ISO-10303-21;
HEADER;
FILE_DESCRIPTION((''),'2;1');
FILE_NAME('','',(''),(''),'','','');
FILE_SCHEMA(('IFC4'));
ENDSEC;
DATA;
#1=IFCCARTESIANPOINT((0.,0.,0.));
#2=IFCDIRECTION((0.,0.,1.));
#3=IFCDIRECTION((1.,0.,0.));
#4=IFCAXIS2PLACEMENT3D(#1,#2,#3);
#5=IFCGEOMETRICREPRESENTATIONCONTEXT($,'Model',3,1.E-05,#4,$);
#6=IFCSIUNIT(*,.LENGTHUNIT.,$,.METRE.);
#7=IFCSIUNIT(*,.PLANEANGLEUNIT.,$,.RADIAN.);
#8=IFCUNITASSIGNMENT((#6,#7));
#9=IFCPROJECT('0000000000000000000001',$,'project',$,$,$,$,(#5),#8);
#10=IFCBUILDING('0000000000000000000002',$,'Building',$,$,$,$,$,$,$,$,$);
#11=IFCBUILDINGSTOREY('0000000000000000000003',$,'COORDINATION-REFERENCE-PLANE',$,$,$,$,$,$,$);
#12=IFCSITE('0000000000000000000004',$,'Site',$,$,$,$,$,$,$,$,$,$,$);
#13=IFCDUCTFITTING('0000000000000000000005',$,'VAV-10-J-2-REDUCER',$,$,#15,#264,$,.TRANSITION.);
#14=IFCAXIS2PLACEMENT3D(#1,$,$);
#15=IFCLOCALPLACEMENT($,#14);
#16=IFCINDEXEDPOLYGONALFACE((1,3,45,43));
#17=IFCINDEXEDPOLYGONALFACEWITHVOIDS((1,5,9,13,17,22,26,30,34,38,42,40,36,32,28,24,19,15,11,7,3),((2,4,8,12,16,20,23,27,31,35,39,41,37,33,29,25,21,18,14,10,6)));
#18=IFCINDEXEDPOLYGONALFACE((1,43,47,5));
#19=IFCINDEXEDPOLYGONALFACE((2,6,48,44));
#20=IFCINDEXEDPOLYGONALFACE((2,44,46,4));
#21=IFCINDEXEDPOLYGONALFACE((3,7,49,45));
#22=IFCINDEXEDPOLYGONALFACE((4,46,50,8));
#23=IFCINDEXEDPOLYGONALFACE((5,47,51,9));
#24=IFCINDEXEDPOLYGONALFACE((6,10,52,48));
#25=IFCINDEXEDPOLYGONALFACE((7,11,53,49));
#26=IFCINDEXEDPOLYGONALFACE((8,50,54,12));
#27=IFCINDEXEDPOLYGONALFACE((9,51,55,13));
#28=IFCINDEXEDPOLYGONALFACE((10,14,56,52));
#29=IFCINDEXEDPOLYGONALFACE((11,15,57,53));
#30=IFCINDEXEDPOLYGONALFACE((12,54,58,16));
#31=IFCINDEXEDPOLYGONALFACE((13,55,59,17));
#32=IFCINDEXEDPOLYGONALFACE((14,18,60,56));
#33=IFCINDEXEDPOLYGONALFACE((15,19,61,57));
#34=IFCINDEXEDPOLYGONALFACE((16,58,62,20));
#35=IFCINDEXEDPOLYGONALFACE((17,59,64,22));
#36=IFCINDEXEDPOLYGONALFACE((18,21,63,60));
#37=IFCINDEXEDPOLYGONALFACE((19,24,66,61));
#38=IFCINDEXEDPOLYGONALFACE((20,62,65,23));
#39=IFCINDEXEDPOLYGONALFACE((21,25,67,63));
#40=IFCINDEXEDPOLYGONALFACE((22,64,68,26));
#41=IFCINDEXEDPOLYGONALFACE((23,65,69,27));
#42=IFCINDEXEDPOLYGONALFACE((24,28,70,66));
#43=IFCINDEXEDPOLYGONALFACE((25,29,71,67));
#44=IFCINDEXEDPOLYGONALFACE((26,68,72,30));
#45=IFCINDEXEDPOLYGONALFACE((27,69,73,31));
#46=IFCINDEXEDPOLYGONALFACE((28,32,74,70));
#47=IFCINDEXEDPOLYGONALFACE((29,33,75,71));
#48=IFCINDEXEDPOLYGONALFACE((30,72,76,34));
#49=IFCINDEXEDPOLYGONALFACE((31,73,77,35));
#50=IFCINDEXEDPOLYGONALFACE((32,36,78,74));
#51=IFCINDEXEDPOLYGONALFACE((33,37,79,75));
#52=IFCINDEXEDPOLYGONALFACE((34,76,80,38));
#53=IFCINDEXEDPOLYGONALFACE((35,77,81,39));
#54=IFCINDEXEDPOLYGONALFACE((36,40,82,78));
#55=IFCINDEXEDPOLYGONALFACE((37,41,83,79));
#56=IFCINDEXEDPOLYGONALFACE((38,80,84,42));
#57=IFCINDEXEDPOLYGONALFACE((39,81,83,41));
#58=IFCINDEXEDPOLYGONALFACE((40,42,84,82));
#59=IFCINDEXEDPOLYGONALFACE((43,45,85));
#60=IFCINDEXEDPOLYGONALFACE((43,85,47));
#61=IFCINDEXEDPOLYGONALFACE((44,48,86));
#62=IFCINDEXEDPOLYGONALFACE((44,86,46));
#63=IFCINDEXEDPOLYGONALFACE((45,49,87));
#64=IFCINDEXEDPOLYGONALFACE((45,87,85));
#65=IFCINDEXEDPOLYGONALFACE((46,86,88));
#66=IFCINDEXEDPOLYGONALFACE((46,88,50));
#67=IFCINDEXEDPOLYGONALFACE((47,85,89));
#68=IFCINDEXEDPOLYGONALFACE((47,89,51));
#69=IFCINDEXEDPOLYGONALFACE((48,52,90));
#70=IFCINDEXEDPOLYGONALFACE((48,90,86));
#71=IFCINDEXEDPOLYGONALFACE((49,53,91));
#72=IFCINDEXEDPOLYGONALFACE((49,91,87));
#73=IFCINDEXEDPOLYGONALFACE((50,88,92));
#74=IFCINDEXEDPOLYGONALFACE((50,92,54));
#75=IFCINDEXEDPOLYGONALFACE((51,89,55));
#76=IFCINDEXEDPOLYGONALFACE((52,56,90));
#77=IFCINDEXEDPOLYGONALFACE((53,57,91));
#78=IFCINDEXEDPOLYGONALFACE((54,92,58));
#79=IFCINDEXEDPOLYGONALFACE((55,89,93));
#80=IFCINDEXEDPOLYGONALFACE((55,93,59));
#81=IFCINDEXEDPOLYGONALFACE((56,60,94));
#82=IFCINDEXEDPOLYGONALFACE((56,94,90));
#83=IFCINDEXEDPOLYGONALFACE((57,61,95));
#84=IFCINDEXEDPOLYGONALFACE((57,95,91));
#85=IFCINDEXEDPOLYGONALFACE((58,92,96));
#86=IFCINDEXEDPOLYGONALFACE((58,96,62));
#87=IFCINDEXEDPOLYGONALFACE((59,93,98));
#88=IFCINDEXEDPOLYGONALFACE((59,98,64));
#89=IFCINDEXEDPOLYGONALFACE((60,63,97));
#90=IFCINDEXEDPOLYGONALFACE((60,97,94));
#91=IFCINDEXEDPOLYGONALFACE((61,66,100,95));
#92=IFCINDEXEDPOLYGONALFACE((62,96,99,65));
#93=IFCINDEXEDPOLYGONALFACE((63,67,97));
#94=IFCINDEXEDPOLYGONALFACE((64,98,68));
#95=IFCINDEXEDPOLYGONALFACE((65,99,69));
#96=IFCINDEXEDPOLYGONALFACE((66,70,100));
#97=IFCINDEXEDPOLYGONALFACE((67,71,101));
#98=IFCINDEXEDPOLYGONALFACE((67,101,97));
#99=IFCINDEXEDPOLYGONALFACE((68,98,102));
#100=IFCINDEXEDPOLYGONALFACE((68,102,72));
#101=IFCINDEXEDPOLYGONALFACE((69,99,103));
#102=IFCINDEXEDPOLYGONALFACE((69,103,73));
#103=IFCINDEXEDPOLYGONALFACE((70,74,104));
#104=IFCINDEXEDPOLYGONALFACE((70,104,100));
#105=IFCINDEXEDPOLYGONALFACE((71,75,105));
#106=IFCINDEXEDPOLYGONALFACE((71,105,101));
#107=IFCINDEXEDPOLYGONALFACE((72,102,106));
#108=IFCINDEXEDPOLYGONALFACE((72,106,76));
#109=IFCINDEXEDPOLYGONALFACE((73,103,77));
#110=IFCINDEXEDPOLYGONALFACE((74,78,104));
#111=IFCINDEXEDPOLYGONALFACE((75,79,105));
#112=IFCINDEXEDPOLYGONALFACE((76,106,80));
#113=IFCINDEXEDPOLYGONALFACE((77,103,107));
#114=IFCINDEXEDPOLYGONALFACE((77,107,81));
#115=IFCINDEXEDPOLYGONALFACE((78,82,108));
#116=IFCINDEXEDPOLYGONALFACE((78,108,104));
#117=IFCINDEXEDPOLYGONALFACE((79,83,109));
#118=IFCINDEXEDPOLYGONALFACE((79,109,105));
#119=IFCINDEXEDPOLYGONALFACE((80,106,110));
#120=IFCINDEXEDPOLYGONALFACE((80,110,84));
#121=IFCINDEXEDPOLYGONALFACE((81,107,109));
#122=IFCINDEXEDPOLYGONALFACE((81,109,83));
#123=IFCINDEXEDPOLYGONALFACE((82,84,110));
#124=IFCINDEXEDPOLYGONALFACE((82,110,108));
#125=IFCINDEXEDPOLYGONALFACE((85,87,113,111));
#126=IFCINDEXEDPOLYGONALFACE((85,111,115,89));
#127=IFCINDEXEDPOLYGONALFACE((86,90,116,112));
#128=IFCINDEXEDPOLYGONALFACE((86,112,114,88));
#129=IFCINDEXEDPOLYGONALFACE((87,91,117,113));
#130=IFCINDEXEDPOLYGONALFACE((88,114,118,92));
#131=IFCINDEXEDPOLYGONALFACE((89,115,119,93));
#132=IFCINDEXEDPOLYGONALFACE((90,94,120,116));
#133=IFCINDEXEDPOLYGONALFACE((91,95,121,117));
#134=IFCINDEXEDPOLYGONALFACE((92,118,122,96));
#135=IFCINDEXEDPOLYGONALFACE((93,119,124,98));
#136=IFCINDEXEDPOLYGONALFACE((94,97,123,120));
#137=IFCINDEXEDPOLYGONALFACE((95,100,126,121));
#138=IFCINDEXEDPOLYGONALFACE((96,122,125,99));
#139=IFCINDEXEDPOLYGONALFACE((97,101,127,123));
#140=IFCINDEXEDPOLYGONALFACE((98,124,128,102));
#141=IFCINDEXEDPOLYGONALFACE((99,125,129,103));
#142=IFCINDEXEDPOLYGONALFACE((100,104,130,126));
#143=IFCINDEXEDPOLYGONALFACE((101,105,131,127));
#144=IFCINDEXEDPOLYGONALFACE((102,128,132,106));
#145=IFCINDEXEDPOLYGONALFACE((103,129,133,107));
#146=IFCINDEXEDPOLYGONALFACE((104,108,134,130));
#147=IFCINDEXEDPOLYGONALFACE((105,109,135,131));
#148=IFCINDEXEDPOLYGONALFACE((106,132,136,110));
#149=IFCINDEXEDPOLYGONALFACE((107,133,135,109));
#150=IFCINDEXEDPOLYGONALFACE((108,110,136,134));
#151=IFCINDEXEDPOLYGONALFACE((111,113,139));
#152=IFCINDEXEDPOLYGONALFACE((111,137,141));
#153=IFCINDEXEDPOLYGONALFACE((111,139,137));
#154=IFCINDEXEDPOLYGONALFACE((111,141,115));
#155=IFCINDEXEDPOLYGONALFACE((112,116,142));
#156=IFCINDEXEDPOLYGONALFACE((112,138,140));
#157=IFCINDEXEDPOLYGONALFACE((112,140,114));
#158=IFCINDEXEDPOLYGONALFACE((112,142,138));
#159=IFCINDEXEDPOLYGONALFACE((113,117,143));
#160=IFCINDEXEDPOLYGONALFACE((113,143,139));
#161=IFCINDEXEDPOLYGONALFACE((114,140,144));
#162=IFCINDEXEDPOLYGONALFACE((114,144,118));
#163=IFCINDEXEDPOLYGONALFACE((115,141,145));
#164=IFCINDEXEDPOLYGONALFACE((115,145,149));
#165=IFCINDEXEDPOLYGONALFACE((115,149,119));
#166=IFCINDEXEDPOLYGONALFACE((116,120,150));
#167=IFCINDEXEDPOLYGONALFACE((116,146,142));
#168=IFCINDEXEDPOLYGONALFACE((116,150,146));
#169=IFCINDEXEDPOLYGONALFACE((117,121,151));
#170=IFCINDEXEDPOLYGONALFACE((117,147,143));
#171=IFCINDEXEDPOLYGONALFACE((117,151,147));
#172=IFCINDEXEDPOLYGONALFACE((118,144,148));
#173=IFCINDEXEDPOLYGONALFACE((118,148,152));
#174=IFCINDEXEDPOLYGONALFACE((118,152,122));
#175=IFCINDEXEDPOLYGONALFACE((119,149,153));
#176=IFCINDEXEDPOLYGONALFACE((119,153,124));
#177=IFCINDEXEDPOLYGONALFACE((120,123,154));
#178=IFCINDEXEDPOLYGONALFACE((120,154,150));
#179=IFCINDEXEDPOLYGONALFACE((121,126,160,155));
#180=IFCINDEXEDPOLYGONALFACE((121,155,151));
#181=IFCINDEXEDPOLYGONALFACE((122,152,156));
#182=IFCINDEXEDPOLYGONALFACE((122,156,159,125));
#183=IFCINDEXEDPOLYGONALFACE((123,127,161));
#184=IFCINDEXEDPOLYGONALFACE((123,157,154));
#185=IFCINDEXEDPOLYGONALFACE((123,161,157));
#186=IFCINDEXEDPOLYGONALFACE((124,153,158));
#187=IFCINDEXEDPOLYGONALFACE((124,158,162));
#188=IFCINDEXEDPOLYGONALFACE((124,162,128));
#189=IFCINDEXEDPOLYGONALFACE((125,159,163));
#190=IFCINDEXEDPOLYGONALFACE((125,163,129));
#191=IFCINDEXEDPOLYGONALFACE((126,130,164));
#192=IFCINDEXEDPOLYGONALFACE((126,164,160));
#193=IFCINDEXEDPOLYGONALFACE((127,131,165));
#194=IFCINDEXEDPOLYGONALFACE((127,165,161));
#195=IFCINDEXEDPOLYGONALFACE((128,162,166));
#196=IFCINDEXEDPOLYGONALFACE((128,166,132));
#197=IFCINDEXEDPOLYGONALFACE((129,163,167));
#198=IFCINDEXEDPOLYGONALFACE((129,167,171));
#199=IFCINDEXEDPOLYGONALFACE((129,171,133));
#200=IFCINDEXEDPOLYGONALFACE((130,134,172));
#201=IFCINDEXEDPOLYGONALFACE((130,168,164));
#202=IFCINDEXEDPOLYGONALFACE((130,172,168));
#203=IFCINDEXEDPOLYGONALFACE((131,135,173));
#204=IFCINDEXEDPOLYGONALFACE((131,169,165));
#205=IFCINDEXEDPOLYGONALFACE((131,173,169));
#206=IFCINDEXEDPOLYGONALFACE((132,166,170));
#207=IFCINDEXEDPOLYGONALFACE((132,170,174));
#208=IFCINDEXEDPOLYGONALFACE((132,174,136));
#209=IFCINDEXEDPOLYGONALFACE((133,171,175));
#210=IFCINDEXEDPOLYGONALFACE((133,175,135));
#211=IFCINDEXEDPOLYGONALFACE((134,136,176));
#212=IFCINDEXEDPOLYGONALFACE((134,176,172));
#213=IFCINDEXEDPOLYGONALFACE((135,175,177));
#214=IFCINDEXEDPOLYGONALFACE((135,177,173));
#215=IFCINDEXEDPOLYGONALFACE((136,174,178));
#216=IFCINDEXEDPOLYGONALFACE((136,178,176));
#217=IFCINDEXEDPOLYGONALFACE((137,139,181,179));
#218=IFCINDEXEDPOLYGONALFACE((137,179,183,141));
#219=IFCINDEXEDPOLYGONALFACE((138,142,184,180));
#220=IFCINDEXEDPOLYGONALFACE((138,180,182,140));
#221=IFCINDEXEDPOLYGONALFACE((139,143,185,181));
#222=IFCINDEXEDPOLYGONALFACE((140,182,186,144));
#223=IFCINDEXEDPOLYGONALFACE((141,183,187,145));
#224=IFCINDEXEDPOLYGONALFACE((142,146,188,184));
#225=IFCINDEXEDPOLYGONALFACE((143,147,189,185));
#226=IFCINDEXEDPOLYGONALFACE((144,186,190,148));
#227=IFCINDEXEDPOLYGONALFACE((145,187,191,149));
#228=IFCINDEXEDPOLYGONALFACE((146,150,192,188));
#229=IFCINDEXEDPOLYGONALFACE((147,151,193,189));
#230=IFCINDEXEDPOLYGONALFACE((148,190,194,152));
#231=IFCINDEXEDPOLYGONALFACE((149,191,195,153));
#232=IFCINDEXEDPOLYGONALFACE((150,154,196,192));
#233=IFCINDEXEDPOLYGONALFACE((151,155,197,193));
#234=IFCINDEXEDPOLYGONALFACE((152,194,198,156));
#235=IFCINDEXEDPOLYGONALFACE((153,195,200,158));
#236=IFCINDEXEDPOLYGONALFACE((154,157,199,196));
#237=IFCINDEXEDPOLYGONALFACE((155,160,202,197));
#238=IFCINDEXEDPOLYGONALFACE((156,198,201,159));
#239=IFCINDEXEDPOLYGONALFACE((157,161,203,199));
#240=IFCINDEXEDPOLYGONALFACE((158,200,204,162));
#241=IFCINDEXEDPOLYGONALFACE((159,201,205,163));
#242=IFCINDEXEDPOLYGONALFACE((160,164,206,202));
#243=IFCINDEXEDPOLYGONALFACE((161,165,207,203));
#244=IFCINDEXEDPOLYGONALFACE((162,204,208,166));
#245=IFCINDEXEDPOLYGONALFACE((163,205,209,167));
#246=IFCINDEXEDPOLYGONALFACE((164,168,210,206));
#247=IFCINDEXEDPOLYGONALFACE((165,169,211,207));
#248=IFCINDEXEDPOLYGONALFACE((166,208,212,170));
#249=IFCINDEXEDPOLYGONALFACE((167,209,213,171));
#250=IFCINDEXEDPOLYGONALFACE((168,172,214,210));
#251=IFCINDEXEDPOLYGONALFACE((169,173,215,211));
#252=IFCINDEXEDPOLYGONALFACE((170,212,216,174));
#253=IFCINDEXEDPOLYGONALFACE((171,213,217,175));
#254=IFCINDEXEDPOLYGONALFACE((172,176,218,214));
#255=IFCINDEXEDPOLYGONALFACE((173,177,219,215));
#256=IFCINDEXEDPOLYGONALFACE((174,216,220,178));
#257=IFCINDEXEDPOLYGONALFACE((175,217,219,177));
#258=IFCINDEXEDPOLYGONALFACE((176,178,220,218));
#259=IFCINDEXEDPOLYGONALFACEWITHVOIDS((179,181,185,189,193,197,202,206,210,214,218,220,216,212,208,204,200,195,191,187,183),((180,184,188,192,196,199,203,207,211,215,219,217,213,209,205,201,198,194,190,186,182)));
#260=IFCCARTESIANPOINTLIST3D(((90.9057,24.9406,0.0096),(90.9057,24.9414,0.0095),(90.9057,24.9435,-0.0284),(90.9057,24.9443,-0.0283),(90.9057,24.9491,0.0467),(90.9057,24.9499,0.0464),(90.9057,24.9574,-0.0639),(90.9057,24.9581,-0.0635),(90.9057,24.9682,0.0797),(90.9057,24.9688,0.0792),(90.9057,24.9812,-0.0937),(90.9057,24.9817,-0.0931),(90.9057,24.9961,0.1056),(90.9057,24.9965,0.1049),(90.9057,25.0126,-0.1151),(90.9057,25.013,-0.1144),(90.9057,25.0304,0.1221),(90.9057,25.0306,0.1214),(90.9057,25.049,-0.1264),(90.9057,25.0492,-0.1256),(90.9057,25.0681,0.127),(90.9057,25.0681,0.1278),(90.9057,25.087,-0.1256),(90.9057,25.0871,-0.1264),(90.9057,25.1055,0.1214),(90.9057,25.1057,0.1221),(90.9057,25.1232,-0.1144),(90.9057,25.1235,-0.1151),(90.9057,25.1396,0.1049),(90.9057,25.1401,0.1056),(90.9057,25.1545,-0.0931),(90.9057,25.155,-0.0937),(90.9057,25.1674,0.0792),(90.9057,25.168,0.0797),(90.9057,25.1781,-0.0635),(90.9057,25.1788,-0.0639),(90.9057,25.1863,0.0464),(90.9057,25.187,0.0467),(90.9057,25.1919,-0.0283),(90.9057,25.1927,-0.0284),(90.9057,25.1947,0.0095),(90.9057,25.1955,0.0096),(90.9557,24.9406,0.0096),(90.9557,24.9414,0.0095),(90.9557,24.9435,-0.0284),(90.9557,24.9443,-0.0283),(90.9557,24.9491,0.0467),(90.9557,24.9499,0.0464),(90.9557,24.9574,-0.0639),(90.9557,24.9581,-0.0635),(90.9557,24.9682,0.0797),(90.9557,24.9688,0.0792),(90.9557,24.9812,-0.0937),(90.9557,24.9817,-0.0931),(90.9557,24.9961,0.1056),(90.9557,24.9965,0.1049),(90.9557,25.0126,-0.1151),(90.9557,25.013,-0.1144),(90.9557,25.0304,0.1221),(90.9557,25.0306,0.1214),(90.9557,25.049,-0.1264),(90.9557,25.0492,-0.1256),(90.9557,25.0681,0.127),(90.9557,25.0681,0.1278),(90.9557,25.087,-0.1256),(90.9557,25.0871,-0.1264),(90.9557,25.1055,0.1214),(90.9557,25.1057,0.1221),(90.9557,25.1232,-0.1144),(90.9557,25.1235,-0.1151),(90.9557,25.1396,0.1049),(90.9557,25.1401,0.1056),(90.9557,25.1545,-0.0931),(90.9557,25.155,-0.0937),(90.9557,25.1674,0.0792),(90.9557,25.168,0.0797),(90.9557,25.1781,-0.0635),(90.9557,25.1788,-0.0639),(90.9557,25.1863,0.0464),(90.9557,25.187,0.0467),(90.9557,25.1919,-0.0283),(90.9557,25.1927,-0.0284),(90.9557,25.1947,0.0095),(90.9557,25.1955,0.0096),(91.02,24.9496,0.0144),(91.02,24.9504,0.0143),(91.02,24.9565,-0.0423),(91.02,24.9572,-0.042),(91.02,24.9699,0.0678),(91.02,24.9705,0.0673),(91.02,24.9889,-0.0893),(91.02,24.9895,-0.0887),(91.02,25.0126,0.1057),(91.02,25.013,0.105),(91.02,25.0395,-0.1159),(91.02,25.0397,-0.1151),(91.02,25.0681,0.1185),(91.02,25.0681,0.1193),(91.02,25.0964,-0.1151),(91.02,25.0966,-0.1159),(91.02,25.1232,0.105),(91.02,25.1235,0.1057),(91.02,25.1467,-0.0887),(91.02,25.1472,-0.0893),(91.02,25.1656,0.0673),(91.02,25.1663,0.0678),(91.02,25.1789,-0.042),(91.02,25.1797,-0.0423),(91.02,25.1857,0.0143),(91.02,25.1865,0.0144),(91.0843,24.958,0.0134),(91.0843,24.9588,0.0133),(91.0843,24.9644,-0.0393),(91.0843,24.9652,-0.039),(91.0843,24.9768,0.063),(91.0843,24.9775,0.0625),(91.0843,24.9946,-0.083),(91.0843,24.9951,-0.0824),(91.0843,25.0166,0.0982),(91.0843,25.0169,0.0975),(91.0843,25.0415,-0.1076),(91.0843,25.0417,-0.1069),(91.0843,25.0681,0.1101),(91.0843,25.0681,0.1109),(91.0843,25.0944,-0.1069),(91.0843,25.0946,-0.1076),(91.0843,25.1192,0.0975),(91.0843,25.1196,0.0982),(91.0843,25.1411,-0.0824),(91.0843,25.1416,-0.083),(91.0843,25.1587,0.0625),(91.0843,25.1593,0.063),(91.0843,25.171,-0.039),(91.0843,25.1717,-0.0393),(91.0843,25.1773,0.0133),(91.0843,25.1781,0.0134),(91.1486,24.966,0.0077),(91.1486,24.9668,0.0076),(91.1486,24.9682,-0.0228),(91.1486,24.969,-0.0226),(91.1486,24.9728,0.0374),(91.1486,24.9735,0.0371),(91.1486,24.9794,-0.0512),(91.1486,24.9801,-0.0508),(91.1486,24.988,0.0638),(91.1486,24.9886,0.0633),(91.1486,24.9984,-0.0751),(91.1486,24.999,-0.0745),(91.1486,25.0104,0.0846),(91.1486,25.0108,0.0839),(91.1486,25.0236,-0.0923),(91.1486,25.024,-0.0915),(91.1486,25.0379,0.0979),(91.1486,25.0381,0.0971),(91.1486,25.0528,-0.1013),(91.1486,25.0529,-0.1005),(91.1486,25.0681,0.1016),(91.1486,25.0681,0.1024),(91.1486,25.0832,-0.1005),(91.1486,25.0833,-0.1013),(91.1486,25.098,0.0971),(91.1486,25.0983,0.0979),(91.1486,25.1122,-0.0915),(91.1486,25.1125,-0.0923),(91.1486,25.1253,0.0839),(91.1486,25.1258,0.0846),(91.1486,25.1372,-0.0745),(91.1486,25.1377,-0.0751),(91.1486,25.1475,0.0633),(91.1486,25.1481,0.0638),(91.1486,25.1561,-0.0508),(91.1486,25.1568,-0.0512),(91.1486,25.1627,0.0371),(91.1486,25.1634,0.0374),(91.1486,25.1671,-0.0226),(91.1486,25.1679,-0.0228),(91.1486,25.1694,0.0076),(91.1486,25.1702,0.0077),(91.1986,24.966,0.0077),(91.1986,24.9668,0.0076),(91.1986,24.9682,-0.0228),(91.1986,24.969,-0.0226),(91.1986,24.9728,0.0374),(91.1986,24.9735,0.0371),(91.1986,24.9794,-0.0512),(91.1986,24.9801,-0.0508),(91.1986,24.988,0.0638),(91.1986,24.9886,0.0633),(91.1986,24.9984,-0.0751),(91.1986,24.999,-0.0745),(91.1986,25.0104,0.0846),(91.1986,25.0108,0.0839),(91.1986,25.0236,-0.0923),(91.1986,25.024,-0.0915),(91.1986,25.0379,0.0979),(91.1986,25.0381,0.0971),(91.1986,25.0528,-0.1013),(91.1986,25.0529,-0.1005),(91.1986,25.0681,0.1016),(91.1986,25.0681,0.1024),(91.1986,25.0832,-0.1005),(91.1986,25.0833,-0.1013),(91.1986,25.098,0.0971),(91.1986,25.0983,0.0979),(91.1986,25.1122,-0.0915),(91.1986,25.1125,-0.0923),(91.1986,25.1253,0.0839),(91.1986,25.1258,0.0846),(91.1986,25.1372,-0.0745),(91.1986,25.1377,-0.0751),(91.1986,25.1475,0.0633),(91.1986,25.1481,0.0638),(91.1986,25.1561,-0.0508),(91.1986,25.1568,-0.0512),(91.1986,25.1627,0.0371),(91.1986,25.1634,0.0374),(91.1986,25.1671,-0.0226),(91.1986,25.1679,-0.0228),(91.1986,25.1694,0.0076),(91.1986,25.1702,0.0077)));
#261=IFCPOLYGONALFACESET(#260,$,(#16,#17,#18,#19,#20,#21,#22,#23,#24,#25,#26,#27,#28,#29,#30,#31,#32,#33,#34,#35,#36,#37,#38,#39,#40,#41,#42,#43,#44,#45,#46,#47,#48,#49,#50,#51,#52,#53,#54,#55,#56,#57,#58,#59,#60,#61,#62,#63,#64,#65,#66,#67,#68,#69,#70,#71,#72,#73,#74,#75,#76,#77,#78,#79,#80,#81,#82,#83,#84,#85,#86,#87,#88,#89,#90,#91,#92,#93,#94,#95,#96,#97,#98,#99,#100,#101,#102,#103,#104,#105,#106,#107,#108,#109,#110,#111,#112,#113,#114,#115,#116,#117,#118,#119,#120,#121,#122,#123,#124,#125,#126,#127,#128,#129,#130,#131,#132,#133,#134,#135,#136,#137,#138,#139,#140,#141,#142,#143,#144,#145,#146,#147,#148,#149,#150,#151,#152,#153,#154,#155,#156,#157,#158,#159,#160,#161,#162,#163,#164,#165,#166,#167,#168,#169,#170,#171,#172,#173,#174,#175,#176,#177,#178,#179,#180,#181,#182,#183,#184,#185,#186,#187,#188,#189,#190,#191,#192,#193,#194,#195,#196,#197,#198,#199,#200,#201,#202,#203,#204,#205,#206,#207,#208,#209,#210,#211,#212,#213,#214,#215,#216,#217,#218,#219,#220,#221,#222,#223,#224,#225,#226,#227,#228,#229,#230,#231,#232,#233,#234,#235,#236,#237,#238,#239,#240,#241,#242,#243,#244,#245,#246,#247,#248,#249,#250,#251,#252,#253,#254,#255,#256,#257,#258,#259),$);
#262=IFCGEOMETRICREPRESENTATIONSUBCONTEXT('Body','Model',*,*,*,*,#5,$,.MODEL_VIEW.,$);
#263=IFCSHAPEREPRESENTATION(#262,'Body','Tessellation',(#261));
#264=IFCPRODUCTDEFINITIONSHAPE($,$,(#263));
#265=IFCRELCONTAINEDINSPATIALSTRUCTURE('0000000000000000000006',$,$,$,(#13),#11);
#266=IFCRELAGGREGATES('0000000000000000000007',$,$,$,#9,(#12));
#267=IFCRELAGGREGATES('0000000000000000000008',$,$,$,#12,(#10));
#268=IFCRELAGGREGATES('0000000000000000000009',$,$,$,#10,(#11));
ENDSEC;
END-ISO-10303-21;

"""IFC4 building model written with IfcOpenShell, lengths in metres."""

from ifc_helpers import new_model, entity, si_unit, frame, origin_with_axes, place, context, subcontext, project, spatial, element, save


model = new_model("IFC4")

# Units and contexts
model_context_1 = context("Model", 3, precision=1e-05, world=origin_with_axes())
body_context_1 = subcontext(model_context_1, "Body", "Model", "MODEL_VIEW")
ifc_project = project(units=[si_unit("LENGTHUNIT", "METRE"), si_unit("PLANEANGLEUNIT", "RADIAN")], contexts=[model_context_1])

# Site, building, storey
site = spatial("IfcSite", under=ifc_project, Name="Site")
building = spatial("IfcBuilding", under=site, Name="Building")
storey = spatial("IfcBuildingStorey", under=building, Name="COORDINATION-REFERENCE-PLANE")

# Duct fitting
for number, where, z_axis, x_axis, name in (
    (1, (90.9057, 25.0681, 0.0), (0.0, 1.0, 0.0), (0.0, 0.0, 1.0), "VAV-10-J-2-REDUCER"),
):
    element("IfcDuctFitting", number, at=place(None, frame(where, z_axis=z_axis, x_axis=x_axis)), inside=storey, Name=name, PredefinedType="TRANSITION", context=body_context_1, shape_type="SweptSolid", body=[
        entity("IfcRevolvedAreaSolid", entity("IfcArbitraryClosedProfileDef", "AREA", None, entity("IfcPolyline", [entity("IfcCartesianPoint", [0.1278, 0.0]), entity("IfcCartesianPoint", [0.1278, 0.05]), entity("IfcCartesianPoint", [0.1024, 0.2429]), entity("IfcCartesianPoint", [0.1024, 0.2929]), entity("IfcCartesianPoint", [0.1016, 0.2929]), entity("IfcCartesianPoint", [0.1016, 0.2429]), entity("IfcCartesianPoint", [0.127, 0.05]), entity("IfcCartesianPoint", [0.127, 0.0]), entity("IfcCartesianPoint", [0.1278, 0.0])])), entity("IfcAxis2Placement3D", entity("IfcCartesianPoint", [0.0, 0.0, 0.0])), entity("IfcAxis1Placement", entity("IfcCartesianPoint", [0.0, 0.0, 0.0]), entity("IfcDirection", [0.0, 1.0, 0.0])), 6.283185),
    ])

save(model, "model.ifc")
